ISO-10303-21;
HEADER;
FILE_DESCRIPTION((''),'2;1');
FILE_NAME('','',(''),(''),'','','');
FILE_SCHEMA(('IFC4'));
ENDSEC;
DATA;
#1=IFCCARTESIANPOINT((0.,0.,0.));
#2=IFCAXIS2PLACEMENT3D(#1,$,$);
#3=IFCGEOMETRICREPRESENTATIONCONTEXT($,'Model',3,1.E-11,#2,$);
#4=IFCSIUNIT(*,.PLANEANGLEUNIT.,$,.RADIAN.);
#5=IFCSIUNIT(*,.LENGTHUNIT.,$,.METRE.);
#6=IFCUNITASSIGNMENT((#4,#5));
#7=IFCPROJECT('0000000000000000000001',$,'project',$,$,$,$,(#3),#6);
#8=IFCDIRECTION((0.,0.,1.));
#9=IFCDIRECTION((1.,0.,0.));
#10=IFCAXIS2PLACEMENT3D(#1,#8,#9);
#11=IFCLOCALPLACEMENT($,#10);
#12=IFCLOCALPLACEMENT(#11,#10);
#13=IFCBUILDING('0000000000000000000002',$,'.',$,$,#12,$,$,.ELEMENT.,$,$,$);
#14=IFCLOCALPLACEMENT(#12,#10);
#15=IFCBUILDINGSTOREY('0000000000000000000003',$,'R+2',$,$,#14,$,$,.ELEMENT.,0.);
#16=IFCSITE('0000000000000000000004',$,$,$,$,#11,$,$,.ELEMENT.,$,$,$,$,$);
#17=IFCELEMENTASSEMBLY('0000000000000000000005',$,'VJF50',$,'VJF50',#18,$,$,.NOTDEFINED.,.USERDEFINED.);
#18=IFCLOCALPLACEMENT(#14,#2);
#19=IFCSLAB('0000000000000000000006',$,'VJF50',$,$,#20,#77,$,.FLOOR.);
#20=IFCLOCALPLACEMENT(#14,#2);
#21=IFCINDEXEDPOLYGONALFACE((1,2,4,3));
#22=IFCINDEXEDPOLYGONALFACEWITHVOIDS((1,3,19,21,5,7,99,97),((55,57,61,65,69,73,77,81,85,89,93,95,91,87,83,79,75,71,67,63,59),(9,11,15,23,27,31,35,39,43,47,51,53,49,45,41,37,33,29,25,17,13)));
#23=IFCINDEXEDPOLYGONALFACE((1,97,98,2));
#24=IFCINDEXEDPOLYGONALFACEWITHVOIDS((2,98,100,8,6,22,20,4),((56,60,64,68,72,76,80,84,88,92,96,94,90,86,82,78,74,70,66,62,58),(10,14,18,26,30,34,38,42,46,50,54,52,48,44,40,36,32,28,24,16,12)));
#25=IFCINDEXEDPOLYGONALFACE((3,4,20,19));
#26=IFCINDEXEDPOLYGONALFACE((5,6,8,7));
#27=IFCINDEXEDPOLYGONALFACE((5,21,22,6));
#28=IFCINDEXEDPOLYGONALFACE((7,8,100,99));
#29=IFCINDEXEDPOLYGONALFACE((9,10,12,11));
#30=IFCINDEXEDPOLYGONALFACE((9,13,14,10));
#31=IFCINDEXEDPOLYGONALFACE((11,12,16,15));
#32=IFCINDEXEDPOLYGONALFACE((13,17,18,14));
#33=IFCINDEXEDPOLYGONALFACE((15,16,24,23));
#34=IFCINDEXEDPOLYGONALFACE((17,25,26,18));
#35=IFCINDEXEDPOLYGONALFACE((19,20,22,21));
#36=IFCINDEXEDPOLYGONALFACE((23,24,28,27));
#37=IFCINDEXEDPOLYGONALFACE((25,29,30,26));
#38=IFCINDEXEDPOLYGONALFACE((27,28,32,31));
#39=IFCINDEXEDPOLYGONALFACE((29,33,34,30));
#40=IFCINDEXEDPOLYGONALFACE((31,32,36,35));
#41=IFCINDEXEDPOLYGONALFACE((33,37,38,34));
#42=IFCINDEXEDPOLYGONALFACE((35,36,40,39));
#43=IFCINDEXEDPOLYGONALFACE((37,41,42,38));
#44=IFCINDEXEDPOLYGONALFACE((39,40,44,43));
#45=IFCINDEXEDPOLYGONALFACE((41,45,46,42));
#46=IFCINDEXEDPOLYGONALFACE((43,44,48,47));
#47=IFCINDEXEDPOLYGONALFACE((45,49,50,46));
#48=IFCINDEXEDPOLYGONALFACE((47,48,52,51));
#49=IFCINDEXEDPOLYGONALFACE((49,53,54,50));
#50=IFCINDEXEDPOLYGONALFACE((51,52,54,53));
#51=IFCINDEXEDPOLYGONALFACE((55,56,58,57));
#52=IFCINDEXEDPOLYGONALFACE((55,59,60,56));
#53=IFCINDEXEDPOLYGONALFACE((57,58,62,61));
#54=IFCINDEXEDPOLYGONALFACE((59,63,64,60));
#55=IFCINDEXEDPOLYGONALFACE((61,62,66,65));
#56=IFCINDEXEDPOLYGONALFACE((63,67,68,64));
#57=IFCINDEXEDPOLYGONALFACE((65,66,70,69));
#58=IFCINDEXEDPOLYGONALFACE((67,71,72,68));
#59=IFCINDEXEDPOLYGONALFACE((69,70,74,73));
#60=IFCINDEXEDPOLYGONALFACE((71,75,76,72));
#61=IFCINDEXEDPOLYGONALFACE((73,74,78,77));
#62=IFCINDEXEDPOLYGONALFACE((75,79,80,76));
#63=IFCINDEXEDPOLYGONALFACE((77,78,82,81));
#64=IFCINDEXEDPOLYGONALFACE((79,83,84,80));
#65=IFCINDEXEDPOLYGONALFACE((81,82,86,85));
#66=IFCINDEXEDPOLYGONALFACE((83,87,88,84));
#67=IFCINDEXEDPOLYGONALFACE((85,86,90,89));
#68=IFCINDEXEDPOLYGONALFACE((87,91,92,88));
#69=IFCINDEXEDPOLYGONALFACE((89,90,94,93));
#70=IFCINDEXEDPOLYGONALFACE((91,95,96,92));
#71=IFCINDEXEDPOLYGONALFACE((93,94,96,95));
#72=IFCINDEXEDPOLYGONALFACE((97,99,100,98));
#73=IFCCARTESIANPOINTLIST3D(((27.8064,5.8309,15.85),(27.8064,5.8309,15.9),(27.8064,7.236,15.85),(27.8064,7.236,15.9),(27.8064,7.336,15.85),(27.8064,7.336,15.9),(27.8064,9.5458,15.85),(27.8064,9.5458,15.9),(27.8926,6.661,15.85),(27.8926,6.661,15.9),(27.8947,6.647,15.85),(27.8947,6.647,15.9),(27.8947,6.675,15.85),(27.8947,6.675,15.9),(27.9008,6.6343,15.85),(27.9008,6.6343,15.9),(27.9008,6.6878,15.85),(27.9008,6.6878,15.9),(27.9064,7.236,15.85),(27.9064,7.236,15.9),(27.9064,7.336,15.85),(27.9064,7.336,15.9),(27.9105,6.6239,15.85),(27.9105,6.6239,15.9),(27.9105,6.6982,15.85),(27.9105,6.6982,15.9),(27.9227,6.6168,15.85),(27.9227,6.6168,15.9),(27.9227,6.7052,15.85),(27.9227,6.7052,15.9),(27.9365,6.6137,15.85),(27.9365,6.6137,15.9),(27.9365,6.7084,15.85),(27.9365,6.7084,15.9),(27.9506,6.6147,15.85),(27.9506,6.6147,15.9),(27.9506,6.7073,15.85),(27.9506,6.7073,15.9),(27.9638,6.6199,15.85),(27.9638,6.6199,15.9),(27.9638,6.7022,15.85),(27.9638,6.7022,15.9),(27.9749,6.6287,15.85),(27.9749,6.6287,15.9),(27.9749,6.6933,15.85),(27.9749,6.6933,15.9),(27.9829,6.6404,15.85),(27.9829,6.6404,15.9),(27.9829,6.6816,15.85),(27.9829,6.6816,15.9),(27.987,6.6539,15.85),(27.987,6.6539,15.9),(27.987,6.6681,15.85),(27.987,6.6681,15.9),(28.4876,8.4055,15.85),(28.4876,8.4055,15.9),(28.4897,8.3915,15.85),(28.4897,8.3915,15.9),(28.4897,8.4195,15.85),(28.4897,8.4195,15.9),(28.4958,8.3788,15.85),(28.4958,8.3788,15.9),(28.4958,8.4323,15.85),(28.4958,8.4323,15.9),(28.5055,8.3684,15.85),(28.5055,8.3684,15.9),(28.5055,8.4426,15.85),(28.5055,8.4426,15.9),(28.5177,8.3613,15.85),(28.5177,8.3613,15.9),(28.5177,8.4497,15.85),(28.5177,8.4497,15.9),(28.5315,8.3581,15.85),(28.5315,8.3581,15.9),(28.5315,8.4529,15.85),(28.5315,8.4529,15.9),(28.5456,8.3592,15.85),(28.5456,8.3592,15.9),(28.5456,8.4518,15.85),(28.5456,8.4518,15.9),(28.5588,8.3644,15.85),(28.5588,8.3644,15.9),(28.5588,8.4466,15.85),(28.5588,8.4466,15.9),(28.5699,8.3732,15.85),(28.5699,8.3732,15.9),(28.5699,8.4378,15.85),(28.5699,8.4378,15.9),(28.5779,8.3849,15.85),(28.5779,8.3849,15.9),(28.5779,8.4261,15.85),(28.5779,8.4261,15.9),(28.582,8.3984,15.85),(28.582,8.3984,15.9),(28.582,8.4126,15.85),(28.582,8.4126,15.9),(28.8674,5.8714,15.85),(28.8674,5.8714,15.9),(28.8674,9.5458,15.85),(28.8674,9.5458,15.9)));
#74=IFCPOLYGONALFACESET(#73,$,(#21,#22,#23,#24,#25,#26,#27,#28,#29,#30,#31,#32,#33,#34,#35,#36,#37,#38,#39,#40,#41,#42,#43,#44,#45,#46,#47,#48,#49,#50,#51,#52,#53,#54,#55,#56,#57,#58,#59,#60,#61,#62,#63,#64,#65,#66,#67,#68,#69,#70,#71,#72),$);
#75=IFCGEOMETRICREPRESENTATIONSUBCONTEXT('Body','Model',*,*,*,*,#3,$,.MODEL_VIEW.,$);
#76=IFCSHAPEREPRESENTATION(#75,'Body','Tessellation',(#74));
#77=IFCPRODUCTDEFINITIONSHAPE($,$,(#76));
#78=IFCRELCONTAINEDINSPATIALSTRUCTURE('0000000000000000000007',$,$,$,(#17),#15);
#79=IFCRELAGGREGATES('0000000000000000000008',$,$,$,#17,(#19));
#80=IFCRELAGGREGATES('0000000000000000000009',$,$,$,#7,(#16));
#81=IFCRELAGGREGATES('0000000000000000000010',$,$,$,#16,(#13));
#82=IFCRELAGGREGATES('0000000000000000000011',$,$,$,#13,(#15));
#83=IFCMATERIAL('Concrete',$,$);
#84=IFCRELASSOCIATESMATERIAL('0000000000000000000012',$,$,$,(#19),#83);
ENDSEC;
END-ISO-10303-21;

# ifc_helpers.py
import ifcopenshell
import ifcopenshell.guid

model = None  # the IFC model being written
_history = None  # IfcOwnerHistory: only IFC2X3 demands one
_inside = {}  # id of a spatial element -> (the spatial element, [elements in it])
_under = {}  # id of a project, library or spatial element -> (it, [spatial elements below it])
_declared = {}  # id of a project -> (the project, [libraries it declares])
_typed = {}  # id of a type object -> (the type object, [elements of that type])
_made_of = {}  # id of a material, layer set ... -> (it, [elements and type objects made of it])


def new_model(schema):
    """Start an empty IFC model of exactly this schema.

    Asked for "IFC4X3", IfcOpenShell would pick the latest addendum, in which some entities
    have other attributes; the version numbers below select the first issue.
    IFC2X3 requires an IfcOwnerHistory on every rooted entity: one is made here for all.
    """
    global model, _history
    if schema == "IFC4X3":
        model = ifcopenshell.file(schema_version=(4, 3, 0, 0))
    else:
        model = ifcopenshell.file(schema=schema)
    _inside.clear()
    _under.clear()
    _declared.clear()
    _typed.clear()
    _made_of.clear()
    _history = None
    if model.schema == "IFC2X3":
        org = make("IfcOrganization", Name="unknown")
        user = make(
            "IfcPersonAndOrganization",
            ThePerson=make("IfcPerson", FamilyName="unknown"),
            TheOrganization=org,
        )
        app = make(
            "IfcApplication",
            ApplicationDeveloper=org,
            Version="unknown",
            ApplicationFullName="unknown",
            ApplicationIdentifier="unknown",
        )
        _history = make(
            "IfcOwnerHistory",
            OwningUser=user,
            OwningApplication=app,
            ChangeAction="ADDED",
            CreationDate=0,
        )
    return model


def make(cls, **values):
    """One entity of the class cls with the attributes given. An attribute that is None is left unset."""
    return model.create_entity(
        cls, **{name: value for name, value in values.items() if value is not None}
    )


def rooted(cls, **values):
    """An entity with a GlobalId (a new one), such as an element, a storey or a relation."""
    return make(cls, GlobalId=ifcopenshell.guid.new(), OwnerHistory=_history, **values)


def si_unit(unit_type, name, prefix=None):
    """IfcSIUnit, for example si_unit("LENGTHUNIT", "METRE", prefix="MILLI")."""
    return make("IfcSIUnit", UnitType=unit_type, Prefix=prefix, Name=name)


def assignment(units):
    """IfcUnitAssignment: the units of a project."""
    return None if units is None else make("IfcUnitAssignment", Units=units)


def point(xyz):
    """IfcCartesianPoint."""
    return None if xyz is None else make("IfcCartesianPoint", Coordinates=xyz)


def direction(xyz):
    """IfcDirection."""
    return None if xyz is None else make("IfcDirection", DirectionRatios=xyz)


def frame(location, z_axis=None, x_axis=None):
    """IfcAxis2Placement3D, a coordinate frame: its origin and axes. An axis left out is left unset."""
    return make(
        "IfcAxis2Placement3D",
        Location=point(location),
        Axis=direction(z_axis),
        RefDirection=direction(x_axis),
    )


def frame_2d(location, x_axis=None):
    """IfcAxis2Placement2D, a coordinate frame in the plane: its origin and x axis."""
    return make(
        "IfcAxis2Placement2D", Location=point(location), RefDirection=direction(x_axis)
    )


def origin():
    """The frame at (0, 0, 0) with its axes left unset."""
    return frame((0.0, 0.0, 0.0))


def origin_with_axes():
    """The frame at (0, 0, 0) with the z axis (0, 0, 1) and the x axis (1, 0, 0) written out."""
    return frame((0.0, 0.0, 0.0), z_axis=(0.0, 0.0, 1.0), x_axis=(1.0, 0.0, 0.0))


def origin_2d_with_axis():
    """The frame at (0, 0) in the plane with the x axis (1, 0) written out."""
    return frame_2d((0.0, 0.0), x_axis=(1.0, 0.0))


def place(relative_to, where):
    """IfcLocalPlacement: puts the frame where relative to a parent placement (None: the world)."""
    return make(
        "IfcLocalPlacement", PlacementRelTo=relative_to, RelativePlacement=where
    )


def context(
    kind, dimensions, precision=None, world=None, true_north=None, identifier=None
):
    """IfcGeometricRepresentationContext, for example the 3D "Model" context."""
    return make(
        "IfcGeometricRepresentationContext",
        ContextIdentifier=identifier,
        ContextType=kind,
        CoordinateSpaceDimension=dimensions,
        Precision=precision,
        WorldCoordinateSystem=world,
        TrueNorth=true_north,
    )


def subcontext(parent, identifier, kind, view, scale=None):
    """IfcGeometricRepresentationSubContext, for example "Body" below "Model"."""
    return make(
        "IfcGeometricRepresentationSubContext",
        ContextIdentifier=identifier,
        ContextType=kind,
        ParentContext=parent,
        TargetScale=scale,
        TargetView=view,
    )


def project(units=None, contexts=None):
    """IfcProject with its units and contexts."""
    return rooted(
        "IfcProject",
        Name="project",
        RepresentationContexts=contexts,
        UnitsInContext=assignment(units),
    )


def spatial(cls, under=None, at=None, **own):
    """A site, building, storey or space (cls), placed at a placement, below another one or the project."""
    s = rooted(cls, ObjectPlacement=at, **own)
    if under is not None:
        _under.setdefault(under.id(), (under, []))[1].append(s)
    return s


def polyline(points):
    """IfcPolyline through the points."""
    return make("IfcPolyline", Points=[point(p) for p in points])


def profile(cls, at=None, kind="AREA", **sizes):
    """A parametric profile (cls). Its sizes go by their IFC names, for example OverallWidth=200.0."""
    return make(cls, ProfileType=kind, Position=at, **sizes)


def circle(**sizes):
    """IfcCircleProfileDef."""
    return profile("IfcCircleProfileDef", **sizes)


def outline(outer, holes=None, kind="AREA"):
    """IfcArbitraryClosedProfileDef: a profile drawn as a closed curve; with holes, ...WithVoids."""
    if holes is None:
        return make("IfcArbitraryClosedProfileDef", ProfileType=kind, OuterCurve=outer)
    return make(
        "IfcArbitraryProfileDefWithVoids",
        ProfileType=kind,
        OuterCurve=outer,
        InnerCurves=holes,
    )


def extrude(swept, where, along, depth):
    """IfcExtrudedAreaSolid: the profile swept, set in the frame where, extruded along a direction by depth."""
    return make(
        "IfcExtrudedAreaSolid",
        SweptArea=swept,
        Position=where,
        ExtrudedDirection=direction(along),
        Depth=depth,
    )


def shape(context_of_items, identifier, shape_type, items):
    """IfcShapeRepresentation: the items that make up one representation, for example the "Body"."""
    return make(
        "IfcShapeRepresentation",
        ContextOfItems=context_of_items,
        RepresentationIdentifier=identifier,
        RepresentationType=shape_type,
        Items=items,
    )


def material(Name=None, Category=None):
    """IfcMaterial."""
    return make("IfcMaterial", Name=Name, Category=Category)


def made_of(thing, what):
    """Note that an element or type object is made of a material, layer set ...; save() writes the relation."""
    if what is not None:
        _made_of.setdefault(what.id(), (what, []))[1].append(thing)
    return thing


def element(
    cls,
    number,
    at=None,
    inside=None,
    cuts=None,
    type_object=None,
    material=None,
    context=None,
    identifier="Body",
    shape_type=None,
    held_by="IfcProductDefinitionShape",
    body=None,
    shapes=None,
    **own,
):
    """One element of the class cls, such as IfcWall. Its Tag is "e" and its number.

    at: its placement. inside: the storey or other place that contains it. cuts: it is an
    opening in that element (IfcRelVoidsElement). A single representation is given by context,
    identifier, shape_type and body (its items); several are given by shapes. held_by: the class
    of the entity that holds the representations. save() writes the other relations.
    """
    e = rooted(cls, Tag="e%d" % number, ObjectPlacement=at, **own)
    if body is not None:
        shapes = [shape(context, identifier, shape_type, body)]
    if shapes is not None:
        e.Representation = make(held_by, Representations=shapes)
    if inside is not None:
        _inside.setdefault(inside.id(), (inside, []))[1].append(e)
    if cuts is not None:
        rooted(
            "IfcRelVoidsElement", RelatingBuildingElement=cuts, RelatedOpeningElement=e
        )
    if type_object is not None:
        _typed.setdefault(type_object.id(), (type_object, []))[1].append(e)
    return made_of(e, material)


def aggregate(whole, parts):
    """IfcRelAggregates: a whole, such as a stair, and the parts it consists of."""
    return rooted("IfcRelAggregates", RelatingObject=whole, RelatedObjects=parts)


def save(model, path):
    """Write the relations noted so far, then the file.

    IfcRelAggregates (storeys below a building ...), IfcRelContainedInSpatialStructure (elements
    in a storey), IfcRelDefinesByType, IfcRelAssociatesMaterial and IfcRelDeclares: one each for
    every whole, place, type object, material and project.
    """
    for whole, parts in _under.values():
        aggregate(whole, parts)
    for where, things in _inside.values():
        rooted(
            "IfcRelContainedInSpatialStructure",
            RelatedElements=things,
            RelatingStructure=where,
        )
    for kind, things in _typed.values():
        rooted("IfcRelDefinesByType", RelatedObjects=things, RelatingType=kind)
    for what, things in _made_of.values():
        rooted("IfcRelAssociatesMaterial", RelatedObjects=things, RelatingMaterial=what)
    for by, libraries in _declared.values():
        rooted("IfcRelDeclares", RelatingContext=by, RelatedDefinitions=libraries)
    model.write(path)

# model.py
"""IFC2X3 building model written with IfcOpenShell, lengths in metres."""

from ifc_helpers import new_model, si_unit, frame, origin, origin_with_axes, origin_2d_with_axis, place, context, subcontext, project, spatial, polyline, circle, outline, extrude, material, element, aggregate, save


model = new_model("IFC2X3")

# Units and contexts
model_context = context("Model", 3, precision=1e-11, world=origin())
body_context = subcontext(model_context, "Body", "Model", "MODEL_VIEW")
ifc_project = project(units=[si_unit("PLANEANGLEUNIT", "RADIAN"), si_unit("LENGTHUNIT", "METRE")], contexts=[model_context])

# Site, building, storey
site_placement = place(None, origin_with_axes())
site = spatial("IfcSite", under=ifc_project, at=site_placement, CompositionType="ELEMENT")
building_placement = place(site_placement, origin_with_axes())
building = spatial("IfcBuilding", under=site, at=building_placement, Name=".", CompositionType="ELEMENT")
storey_placement = place(building_placement, origin_with_axes())
storey = spatial("IfcBuildingStorey", under=building, at=storey_placement, Name="R+2", CompositionType="ELEMENT", Elevation=0.0)

# Element assembly, slab, openings
assembly_1_placement = place(storey_placement, origin_with_axes())
assembly_1 = element("IfcElementAssembly", 1, at=assembly_1_placement, inside=storey, Name="VJF50", ObjectType="VJF50", AssemblyPlace="NOTDEFINED", PredefinedType="USERDEFINED")
ifc_material = material(Name="Concrete")
slab_1_placement = place(assembly_1_placement, frame((28.8674, 5.8309, 15.85), z_axis=(0.0, 0.0, 1.0), x_axis=(0.0, 1.0, 0.0)))
slab_1 = element("IfcSlab", 2, at=slab_1_placement, material=ifc_material, Name="VJF50", PredefinedType="FLOOR", context=body_context, shape_type="SweptSolid", body=[
    extrude(outline(polyline([(0.0, -0.0405), (0.0, -3.7149), (1.0611, -3.7149), (1.0611, 0.0), (0.0, -0.0405)])), frame((0.0, 0.0, 0.0), z_axis=(0.0, 0.0, 1.0), x_axis=(0.0, 1.0, 0.0)), (0.0, 0.0, 1.0), 0.05),
])
opening_1_placement = place(slab_1_placement, frame((2.5746, 0.3324, 0.0), z_axis=(0.0, 0.0, 1.0), x_axis=(1.0, 0.0, 0.0)))
element("IfcOpeningElement", 3, at=opening_1_placement, cuts=slab_1, ObjectType="Opening", context=body_context, shape_type="SweptSolid", body=[
    extrude(circle(Radius=0.0475, at=origin_2d_with_axis()), frame((0.0, 0.0, 0.0), z_axis=(0.0, 0.0, 1.0), x_axis=(0.0, 1.0, 0.0)), (0.0, 0.0, 1.0), 0.05),
])
opening_2_placement = place(slab_1_placement, frame((0.8301, 0.9274, 0.0), z_axis=(0.0, 0.0, 1.0), x_axis=(1.0, 0.0, 0.0)))
element("IfcOpeningElement", 4, at=opening_2_placement, cuts=slab_1, ObjectType="Opening", context=body_context, shape_type="SweptSolid", body=[
    extrude(circle(Radius=0.0475, at=origin_2d_with_axis()), frame((0.0, 0.0, 0.0), z_axis=(0.0, 0.0, 1.0), x_axis=(0.0, 1.0, 0.0)), (0.0, 0.0, 1.0), 0.05),
])
opening_3_placement = place(slab_1_placement, origin_with_axes())
element("IfcOpeningElement", 5, at=opening_3_placement, cuts=slab_1, ObjectType="Opening", context=body_context, shape_type="SweptSolid", body=[
    extrude(outline(polyline([(0.961, -1.4051), (0.961, -1.5051), (1.0611, -1.5051), (1.0611, -1.4051), (0.961, -1.4051)])), frame((0.0, 0.0, 0.0), z_axis=(0.0, 0.0, 1.0), x_axis=(0.0, 1.0, 0.0)), (0.0, 0.0, 1.0), 0.05),
])

aggregate(assembly_1, [slab_1])

save(model, "model.ifc")
